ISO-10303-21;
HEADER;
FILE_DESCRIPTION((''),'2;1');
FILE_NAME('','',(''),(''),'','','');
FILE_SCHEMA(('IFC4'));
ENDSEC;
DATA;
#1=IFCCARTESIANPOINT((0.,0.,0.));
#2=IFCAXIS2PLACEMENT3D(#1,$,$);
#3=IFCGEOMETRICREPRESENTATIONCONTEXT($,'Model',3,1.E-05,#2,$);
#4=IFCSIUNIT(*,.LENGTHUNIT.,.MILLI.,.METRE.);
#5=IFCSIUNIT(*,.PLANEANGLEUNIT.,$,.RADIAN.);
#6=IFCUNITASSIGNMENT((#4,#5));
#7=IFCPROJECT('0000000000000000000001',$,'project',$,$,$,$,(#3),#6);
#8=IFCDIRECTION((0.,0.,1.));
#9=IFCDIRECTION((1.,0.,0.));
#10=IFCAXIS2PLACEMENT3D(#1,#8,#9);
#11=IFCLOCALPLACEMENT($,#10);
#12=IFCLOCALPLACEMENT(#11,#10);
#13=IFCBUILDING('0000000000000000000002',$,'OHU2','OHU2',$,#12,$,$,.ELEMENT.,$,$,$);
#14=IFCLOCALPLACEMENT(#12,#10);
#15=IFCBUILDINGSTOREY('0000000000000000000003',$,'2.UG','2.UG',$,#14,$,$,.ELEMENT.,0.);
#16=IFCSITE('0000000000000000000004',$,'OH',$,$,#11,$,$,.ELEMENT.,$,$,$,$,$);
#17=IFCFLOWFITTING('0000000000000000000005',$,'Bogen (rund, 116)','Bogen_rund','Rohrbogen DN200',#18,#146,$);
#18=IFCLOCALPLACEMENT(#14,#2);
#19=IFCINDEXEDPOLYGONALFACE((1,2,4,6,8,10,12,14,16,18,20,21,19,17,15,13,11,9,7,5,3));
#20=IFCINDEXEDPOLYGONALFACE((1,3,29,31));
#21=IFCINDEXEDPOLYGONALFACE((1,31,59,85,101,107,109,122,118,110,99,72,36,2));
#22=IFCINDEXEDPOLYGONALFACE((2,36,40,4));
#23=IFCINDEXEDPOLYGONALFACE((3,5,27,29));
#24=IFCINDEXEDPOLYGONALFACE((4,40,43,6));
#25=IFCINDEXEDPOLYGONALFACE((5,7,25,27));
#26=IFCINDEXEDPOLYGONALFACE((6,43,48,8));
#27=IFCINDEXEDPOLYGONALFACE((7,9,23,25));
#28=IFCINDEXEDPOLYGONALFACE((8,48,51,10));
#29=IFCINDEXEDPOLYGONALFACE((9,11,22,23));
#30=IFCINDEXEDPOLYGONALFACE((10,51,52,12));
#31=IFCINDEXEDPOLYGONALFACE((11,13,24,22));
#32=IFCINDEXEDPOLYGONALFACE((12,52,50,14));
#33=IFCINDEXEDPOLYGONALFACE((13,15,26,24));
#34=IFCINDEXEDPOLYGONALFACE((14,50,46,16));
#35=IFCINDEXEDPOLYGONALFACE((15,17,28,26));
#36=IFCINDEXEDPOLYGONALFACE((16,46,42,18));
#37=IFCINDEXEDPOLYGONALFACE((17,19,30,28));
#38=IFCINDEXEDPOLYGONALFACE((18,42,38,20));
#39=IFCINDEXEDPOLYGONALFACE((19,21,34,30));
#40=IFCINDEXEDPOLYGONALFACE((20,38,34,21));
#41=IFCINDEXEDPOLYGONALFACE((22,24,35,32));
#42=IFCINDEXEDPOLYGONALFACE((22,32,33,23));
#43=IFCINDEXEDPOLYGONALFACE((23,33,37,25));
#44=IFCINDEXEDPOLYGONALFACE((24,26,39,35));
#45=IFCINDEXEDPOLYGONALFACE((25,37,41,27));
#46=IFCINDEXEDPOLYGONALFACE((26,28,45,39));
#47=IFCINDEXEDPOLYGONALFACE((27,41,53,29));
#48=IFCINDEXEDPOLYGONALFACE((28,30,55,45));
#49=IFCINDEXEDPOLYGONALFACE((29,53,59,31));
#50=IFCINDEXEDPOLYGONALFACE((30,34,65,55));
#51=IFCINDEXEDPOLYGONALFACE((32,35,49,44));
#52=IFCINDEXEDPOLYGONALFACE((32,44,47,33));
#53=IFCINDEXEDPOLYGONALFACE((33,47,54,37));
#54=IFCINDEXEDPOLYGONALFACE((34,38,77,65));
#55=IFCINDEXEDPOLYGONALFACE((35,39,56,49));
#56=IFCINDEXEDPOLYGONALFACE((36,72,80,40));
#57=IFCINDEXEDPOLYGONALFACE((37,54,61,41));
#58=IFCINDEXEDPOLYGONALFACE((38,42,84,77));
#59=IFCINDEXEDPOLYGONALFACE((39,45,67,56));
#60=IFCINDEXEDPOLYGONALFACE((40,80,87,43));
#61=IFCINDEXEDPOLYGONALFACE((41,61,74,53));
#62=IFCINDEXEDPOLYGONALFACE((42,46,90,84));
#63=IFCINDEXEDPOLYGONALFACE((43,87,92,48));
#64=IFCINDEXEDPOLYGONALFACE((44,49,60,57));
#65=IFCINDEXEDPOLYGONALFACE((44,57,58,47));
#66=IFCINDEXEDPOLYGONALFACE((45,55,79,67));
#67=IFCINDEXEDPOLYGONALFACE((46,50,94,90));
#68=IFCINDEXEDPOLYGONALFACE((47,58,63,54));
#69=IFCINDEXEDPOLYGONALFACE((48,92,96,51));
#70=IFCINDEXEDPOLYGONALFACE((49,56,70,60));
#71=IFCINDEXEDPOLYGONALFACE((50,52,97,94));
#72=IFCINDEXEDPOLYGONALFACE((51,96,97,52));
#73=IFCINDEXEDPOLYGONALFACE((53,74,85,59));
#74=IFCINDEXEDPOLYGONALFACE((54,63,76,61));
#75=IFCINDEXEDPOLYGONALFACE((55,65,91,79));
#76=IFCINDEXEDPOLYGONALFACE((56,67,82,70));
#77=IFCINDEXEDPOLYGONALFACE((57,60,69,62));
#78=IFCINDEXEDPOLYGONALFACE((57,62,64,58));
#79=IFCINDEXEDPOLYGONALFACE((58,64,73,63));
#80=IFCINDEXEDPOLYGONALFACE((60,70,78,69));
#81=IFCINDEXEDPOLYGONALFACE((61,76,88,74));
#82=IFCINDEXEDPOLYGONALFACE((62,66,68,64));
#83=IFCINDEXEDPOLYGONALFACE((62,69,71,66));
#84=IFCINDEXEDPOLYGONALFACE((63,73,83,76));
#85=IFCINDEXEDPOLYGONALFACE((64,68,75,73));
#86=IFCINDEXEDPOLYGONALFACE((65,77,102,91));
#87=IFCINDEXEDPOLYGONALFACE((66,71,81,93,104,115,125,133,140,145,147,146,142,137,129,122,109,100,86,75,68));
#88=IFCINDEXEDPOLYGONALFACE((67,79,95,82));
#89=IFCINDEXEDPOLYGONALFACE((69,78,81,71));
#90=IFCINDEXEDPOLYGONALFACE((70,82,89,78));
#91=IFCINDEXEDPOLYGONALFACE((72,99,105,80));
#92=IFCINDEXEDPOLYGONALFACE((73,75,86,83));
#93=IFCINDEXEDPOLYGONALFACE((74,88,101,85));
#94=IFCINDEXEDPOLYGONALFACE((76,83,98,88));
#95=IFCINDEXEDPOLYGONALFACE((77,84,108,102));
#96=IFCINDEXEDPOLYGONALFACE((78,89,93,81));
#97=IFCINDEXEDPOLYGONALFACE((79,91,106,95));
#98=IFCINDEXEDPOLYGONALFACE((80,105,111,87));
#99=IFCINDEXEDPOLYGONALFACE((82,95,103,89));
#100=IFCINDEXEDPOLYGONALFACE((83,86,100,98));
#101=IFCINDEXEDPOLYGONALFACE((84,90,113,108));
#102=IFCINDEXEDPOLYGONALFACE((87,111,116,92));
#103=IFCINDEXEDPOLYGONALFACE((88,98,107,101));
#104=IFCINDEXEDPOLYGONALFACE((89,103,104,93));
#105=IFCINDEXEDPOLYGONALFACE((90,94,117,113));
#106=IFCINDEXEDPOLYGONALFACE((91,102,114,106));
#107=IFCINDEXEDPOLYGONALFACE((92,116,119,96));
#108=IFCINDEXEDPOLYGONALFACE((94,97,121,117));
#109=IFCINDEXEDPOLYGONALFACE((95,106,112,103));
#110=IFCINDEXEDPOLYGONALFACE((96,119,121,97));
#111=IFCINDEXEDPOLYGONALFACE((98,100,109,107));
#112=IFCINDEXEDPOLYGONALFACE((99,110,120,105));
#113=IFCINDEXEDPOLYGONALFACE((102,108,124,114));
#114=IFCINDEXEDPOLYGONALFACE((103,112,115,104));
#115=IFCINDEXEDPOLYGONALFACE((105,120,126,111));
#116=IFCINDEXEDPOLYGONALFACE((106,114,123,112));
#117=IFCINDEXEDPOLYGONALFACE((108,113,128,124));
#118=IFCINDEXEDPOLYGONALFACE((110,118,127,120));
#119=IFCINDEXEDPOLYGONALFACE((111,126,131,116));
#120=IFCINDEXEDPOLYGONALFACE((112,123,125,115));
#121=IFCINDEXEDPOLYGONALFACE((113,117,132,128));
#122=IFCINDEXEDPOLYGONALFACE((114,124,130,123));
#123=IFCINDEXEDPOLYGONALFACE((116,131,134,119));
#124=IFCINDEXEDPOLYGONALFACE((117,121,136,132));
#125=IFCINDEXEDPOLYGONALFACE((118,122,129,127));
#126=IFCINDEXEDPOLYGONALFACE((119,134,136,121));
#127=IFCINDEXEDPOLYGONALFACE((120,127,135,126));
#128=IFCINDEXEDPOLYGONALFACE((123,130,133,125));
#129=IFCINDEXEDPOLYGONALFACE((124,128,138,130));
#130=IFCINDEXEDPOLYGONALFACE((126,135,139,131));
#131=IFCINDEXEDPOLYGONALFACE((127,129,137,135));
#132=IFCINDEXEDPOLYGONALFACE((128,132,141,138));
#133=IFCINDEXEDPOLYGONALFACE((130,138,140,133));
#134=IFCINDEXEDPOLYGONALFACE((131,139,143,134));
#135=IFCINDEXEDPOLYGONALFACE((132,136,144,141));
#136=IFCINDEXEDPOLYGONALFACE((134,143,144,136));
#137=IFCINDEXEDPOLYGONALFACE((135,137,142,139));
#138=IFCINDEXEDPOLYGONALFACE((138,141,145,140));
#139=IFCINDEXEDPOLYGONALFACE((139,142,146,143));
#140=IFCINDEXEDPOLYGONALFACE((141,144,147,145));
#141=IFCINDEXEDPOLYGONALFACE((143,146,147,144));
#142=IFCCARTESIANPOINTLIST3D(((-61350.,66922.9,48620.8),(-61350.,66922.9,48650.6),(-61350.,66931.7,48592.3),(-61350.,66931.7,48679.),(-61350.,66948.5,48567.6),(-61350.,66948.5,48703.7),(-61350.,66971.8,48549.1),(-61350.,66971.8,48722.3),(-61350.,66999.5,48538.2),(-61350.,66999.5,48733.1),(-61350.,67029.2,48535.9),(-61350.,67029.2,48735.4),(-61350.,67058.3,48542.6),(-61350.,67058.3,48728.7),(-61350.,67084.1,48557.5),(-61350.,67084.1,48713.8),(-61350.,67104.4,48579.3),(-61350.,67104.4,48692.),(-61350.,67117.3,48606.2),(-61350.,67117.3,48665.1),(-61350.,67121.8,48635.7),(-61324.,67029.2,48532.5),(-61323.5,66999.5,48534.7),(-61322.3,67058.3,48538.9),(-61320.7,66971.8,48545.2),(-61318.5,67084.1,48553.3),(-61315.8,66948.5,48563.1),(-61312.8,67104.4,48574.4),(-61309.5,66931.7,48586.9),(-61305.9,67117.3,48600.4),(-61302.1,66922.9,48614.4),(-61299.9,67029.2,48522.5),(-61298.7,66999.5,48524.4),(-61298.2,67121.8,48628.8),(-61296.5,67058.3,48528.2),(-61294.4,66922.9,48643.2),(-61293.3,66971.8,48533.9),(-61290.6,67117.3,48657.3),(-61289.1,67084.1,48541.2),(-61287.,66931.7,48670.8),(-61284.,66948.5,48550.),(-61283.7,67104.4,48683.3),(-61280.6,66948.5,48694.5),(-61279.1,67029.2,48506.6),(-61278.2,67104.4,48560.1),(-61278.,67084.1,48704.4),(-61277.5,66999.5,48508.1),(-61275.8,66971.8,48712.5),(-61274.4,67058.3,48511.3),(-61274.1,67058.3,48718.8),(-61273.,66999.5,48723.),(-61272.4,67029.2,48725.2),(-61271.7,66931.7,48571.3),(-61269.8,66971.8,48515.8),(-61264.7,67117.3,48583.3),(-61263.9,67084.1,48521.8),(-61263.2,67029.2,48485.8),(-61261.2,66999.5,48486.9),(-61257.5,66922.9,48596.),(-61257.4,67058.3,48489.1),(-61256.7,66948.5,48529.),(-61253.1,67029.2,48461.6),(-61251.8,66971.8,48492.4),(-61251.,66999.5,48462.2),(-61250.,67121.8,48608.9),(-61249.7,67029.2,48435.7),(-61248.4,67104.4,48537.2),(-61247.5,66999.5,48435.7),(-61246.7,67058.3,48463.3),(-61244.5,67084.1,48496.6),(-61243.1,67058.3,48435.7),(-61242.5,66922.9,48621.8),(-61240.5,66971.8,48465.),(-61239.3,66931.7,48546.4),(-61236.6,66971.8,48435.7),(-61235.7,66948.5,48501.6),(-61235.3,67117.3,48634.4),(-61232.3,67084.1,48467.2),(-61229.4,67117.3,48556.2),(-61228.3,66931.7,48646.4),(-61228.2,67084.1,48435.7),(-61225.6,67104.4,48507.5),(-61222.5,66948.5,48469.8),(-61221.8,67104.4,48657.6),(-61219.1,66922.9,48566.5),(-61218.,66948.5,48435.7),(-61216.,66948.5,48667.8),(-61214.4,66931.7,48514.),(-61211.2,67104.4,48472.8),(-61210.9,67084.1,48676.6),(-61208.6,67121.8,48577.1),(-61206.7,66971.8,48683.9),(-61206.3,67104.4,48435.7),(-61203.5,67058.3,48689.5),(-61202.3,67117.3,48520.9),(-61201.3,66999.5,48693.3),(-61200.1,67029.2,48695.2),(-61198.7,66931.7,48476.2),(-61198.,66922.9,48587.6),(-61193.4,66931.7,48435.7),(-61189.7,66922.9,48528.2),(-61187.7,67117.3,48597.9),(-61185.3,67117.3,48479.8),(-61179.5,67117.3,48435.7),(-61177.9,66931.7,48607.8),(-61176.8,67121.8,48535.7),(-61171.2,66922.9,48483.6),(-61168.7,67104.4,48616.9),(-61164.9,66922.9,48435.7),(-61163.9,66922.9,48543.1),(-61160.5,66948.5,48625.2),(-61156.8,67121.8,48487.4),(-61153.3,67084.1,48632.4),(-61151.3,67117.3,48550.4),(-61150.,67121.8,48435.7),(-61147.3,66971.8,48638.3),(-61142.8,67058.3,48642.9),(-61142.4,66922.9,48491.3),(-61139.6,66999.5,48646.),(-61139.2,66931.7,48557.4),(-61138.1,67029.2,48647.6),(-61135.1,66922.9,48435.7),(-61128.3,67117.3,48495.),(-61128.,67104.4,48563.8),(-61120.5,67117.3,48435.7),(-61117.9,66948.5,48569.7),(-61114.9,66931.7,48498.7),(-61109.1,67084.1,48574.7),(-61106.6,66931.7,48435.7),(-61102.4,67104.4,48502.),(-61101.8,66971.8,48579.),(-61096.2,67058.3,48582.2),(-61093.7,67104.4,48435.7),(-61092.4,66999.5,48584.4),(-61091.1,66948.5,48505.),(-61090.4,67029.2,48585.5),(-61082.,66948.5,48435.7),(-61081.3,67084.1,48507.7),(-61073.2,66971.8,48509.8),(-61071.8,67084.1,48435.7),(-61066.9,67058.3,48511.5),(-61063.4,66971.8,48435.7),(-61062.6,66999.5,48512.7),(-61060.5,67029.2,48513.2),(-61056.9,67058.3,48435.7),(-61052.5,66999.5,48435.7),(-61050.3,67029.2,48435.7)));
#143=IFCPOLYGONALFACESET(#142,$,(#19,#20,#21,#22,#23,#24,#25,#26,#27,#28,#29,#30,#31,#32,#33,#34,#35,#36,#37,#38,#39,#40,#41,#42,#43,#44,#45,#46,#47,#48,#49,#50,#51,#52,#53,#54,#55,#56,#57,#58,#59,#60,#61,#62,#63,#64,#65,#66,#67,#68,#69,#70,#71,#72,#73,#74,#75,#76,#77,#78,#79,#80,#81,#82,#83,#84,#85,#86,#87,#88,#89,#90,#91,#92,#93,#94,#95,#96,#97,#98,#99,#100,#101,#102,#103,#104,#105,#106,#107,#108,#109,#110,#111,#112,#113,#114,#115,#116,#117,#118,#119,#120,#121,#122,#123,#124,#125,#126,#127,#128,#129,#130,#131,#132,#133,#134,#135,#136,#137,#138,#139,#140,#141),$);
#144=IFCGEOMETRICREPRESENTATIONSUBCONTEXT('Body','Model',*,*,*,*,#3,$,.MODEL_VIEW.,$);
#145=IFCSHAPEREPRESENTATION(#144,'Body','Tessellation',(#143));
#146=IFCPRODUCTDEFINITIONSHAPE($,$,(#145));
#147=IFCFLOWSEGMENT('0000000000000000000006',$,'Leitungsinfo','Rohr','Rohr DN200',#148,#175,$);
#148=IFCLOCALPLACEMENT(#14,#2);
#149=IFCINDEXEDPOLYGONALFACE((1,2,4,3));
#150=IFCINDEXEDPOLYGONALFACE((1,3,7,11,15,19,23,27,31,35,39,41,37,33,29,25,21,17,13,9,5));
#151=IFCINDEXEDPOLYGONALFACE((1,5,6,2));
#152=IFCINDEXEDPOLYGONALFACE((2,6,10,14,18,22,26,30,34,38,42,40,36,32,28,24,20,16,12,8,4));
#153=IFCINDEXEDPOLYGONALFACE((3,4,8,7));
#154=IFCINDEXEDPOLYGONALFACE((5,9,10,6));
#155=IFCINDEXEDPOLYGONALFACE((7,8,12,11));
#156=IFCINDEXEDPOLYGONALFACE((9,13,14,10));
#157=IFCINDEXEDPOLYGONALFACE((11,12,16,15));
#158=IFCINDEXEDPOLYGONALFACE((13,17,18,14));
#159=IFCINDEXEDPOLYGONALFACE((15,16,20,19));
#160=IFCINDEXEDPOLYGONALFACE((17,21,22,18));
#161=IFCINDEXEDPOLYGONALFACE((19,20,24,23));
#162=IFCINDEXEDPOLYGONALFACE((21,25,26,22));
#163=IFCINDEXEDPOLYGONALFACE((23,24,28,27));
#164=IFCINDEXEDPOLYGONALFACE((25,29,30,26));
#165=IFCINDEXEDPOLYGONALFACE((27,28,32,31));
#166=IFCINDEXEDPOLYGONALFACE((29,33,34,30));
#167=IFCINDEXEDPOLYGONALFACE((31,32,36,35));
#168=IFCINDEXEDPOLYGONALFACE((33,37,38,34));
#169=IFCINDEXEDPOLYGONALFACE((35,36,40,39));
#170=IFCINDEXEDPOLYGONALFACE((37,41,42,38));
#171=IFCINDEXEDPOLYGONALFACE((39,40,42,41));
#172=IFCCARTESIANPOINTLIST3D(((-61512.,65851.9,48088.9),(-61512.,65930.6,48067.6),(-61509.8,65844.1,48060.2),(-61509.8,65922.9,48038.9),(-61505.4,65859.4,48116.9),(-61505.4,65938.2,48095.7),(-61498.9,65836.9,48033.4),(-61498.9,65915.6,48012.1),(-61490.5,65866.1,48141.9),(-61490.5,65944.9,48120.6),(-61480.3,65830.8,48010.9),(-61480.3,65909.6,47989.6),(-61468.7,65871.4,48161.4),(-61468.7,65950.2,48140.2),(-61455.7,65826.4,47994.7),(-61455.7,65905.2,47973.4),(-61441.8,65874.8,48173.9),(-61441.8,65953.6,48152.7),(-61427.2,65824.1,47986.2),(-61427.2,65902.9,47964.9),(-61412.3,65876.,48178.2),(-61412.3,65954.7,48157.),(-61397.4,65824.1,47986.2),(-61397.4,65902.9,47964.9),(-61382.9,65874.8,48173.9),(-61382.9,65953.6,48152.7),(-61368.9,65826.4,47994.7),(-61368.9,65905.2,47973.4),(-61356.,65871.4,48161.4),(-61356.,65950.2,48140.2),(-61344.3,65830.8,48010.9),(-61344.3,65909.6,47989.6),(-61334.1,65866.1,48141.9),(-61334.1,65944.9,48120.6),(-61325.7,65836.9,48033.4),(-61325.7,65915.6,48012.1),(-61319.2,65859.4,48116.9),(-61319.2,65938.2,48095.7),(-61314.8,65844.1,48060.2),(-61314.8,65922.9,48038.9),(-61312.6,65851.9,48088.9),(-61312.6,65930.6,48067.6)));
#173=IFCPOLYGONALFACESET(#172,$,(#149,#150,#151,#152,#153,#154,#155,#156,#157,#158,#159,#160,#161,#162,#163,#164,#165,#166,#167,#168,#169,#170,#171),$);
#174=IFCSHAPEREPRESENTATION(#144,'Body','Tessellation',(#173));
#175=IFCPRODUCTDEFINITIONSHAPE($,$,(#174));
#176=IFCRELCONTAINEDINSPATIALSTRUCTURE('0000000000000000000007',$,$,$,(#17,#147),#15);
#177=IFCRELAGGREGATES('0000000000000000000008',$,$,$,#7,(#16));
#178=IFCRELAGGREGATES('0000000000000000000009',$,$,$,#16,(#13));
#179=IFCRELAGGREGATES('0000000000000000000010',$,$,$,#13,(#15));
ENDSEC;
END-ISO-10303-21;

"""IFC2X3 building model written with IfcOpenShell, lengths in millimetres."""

from ifc_helpers import new_model, entity, si_unit, frame, origin, origin_with_axes, origin_2d_with_axis, place, context, subcontext, project, spatial, circle, extrude, element, save


model = new_model("IFC2X3")

# Units and contexts
model_context = context("Model", 3, precision=1e-05, world=origin())
body_context = subcontext(model_context, "Body", "Model", "MODEL_VIEW")
ifc_project = project(units=[si_unit("LENGTHUNIT", "METRE", prefix="MILLI"), si_unit("PLANEANGLEUNIT", "RADIAN")], contexts=[model_context])

# Site, building, storey
site_placement = place(None, origin_with_axes())
site = spatial("IfcSite", under=ifc_project, at=site_placement, Name="OH", CompositionType="ELEMENT")
building_placement = place(site_placement, origin_with_axes())
building = spatial("IfcBuilding", under=site, at=building_placement, Name="OHU2", Description="OHU2", CompositionType="ELEMENT")
storey_placement = place(building_placement, origin_with_axes())
storey = spatial("IfcBuildingStorey", under=building, at=storey_placement, Name="2.UG", Description="2.UG", CompositionType="ELEMENT", Elevation=0.0)

# Flow fitting
flow_fitting_1_placement = place(storey_placement, frame((-61200.0, 67021.8, 48585.7), z_axis=(0.0, 0.0, 1.0), x_axis=(1.0, 0.0, 0.0)))
element("IfcFlowFitting", 1, at=flow_fitting_1_placement, inside=storey, Name="Bogen (rund, 116)", Description="Bogen_rund", ObjectType="Rohrbogen DN200", context=body_context, shape_type="SweptSolid", body=[
    entity("IfcRevolvedAreaSolid", entity("IfcCircleProfileDef", "AREA", None, entity("IfcAxis2Placement2D", entity("IfcCartesianPoint", [0.0, 0.0]), entity("IfcDirection", [1.0, 0.0])), 100.0), entity("IfcAxis2Placement3D", entity("IfcCartesianPoint", [50.0, 0.0, -150.0]), entity("IfcDirection", [0.0, 0.0, 1.0]), entity("IfcDirection", [-0.000002, 1.0, 0.0])), entity("IfcAxis1Placement", entity("IfcCartesianPoint", [0.0, 200.0, 0.0]), entity("IfcDirection", [-1.0, 0.0, 0.0])), 1.570796),
])

# Flow segment
flow_segment_1_placement = place(storey_placement, frame((-61412.3, 65889.3, 48071.0), z_axis=(0.0, 0.0, 1.0), x_axis=(1.0, 0.0, 0.0)))
element("IfcFlowSegment", 2, at=flow_segment_1_placement, inside=storey, Name="Leitungsinfo", Description="Rohr", ObjectType="Rohr DN200", context=body_context, shape_type="SweptSolid", body=[
    extrude(circle(Radius=100.0, at=origin_2d_with_axis()), frame((0.0, -39.4, 10.6), z_axis=(0.0, 0.965475, -0.260497), x_axis=(0.0, 0.0, 1.0)), (0.0, 0.0, 1.0), 81.6),
])

save(model, "model.ifc")
